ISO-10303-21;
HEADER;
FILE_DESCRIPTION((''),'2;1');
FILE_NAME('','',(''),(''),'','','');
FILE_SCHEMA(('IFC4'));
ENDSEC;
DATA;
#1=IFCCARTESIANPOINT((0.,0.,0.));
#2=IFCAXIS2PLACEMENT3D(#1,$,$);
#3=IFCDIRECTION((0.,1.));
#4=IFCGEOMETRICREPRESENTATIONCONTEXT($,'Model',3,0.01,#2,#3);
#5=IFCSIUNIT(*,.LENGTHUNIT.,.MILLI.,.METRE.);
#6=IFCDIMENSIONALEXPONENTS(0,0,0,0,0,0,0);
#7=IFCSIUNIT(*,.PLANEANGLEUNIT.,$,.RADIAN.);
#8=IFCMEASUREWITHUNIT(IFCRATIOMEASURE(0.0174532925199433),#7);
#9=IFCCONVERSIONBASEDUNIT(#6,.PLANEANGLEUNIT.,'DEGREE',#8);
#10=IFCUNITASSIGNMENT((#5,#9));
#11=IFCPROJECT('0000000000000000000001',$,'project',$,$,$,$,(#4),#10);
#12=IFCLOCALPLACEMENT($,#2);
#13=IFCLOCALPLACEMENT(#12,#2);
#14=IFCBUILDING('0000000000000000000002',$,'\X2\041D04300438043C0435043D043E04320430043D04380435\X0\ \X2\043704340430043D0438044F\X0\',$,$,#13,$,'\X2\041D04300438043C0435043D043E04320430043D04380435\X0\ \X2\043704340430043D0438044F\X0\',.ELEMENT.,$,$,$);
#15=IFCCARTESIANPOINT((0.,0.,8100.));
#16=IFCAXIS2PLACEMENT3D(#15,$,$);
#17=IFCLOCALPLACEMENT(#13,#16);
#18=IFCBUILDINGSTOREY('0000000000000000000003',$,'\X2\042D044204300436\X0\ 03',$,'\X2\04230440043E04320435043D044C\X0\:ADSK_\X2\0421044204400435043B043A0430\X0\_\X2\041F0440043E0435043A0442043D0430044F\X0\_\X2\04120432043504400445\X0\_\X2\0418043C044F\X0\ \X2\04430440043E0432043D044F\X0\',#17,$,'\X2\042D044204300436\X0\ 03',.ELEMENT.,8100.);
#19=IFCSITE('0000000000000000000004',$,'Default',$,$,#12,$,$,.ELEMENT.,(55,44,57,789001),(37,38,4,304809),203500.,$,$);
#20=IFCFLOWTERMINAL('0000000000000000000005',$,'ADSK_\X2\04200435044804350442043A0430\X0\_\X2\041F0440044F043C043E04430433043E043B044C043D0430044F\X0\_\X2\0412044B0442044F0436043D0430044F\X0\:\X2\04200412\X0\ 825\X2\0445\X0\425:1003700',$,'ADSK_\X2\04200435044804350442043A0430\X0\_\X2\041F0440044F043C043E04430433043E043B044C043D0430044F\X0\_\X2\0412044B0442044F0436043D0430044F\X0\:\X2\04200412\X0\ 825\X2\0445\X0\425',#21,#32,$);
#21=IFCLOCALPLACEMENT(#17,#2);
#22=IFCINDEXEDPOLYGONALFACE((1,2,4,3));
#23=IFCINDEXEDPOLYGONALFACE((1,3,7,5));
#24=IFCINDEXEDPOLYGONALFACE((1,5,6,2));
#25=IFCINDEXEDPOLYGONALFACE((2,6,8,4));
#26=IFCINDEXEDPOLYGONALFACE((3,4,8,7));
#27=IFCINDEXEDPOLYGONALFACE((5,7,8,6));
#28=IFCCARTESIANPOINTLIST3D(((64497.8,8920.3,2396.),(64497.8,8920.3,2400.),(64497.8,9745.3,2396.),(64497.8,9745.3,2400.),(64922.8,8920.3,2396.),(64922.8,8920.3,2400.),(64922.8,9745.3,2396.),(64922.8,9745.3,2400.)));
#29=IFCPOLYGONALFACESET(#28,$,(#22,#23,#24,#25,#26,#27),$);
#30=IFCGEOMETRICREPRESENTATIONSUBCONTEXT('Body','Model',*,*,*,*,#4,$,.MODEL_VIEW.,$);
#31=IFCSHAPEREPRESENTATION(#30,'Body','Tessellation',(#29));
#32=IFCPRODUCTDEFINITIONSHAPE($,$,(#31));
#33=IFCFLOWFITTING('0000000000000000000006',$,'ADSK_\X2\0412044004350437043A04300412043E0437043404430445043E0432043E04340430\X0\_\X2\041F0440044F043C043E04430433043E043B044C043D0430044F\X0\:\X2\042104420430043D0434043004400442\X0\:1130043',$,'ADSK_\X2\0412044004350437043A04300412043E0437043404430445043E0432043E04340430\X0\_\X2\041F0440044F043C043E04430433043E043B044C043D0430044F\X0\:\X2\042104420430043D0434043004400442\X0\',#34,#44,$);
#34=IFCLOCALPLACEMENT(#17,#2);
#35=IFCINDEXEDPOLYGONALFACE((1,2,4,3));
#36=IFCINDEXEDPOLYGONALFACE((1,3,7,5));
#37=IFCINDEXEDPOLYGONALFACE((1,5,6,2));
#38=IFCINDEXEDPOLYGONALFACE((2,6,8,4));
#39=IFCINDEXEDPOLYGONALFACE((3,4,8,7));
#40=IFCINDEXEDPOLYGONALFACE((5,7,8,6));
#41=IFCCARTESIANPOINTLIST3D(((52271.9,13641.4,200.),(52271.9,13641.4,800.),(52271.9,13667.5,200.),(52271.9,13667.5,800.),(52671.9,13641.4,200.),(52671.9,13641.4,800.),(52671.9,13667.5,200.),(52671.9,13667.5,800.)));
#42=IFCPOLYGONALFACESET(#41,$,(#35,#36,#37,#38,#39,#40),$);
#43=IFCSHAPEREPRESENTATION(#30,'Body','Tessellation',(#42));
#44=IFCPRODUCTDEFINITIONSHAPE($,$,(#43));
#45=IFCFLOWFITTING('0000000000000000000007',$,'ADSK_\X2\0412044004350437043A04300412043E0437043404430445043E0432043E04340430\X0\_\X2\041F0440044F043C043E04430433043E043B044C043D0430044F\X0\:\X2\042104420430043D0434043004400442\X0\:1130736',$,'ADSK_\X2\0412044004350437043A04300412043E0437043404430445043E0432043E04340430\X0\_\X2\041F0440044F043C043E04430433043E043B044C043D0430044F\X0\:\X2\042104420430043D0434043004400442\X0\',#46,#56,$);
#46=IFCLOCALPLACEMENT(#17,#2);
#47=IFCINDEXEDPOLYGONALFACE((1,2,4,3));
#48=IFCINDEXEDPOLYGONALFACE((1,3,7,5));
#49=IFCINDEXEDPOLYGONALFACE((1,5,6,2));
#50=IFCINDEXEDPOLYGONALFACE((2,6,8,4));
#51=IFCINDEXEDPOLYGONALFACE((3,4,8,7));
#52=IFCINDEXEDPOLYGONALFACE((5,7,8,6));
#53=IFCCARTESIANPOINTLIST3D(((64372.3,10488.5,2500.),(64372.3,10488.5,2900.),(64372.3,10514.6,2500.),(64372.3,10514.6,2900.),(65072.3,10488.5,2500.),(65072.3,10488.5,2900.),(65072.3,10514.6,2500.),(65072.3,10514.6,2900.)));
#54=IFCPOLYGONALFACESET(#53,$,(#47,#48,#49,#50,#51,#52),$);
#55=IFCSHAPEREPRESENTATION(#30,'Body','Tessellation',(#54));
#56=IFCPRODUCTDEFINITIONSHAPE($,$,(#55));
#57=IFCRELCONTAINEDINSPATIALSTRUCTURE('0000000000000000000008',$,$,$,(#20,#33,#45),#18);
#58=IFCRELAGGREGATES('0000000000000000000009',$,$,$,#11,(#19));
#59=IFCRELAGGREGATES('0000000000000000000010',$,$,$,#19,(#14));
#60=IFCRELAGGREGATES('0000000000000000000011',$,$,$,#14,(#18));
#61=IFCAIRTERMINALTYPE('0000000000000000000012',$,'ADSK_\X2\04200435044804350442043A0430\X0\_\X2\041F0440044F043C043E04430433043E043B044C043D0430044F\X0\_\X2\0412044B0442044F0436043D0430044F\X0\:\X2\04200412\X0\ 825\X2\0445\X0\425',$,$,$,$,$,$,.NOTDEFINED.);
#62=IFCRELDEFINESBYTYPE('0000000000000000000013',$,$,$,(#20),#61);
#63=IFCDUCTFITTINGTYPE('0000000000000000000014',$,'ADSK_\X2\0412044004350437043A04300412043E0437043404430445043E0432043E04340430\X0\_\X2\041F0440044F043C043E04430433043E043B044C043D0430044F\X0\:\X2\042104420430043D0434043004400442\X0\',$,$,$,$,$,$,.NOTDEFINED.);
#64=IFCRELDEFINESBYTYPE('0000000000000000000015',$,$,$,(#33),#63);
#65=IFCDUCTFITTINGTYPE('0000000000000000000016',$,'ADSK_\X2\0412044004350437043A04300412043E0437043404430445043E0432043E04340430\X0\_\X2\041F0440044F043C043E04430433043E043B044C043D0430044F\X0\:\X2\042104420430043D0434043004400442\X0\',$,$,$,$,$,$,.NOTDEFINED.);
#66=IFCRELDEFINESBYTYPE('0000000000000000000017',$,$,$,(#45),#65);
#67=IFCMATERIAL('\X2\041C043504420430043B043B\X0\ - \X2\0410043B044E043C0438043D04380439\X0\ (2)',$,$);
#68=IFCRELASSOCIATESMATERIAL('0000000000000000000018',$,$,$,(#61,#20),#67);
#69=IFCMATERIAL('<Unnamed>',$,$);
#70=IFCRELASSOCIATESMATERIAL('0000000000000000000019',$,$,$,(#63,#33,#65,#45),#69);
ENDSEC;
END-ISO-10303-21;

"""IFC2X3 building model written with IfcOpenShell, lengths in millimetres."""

from ifc_helpers import new_model, entity, si_unit, converted_unit, direction, frame, origin, origin_2d_with_axis, place, context, subcontext, project, spatial, rectangle, extrude, source, transform, mapped, material, type_object, type_shapes, element, save


model = new_model("IFC2X3")

# Units and contexts
model_context = context("Model", 3, precision=0.01, world=origin(), true_north=direction((0.0, 1.0)))
body_context = subcontext(model_context, "Body", "Model", "MODEL_VIEW")
ifc_project = project(units=[si_unit("LENGTHUNIT", "METRE", prefix="MILLI"), converted_unit("PLANEANGLEUNIT", "DEGREE", entity("IfcRatioMeasure", 0.0174532925199433), si_unit("PLANEANGLEUNIT", "RADIAN"), dimensions=[0, 0, 0, 0, 0, 0, 0])], contexts=[model_context])

# Site, building, storey
site_placement = place(None, origin())
site = spatial("IfcSite", under=ifc_project, at=site_placement, Name="Default", CompositionType="ELEMENT", RefLatitude=(55, 44, 57, 789001), RefLongitude=(37, 38, 4, 304809), RefElevation=203500.0)
building_placement = place(site_placement, origin())
building = spatial("IfcBuilding", under=site, at=building_placement, Name="Наименование здания", LongName="Наименование здания", CompositionType="ELEMENT")
storey_placement = place(building_placement, frame((0.0, 0.0, 8100.0)))
storey = spatial("IfcBuildingStorey", under=building, at=storey_placement, Name="Этаж 03", ObjectType="Уровень:ADSK_Стрелка_Проектная_Вверх_Имя уровня", LongName="Этаж 03", CompositionType="ELEMENT", Elevation=8100.0)

# Shared definitions
ifc_material_1 = material(Name="<Unnamed>")

# Flow terminal
ifc_material_2 = material(Name="Металл - Алюминий (2)")
air_terminal_type = type_object("IfcAirTerminalType", Name="ADSK_Решетка_Прямоугольная_Вытяжная:РВ 825х425", PredefinedType="NOTDEFINED", material=ifc_material_2)
shared_shape_1 = source(origin(), body_context, "Body", "SweptSolid", [
    extrude(rectangle(XDim=4.0, YDim=825.0, at=origin_2d_with_axis()), frame((0.0, -2.0, -212.5), z_axis=(0.0, 0.0, 1.0), x_axis=(0.0, 1.0, 0.0)), (0.0, 0.0, 1.0), 425.0),
])
type_shapes(air_terminal_type, [shared_shape_1])
flow_terminal_placement = place(storey_placement, frame((64710.3, 9332.8, 2400.0), z_axis=(1.0, 0.0, 0.0), x_axis=(0.0, 1.0, 0.0)))
element("IfcFlowTerminal", 1, at=flow_terminal_placement, inside=storey, type_object=air_terminal_type, material=ifc_material_2, Name="ADSK_Решетка_Прямоугольная_Вытяжная:РВ 825х425:1003700", ObjectType="ADSK_Решетка_Прямоугольная_Вытяжная:РВ 825х425", context=body_context, shape_type="MappedRepresentation", body=[
    mapped(shared_shape_1, transform((0.0, 0.0, 0.0), scale=1.0)),
])

# Flow fittings
duct_fitting_type_1 = type_object("IfcDuctFittingType", Name="ADSK_ВрезкаВоздуховода_Прямоугольная:Стандарт", PredefinedType="NOTDEFINED", material=ifc_material_1)
shared_shape_2 = source(origin(), body_context, "Body", "SweptSolid", [
    extrude(rectangle(XDim=600.0, YDim=26.1, at=origin_2d_with_axis()), frame((7.0, 0.0, -200.0), z_axis=(0.0, 0.0, 1.0), x_axis=(0.0, -1.0, 0.0)), (0.0, 0.0, 1.0), 400.0),
])
type_shapes(duct_fitting_type_1, [shared_shape_2])
flow_fitting_1_placement = place(storey_placement, frame((52471.9, 13647.5, 500.0), z_axis=(1.0, 0.0, 0.0), x_axis=(0.0, 1.0, 0.0)))
element("IfcFlowFitting", 2, at=flow_fitting_1_placement, inside=storey, type_object=duct_fitting_type_1, material=ifc_material_1, Name="ADSK_ВрезкаВоздуховода_Прямоугольная:Стандарт:1130043", ObjectType="ADSK_ВрезкаВоздуховода_Прямоугольная:Стандарт", context=body_context, shape_type="MappedRepresentation", body=[
    mapped(shared_shape_2, transform((0.0, 0.0, 0.0), scale=1.0)),
])
duct_fitting_type_2 = type_object("IfcDuctFittingType", Name="ADSK_ВрезкаВоздуховода_Прямоугольная:Стандарт", PredefinedType="NOTDEFINED", material=ifc_material_1)
shared_shape_3 = source(origin(), body_context, "Body", "SweptSolid", [
    extrude(rectangle(XDim=26.1, YDim=700.0, at=origin_2d_with_axis()), frame((7.0, 0.0, -200.0)), (0.0, 0.0, 1.0), 400.0),
])
type_shapes(duct_fitting_type_2, [shared_shape_3])
flow_fitting_2_placement = place(storey_placement, frame((64722.3, 10508.5, 2700.0), z_axis=(0.0, 0.0, -1.0), x_axis=(0.0, -1.0, 0.0)))
element("IfcFlowFitting", 3, at=flow_fitting_2_placement, inside=storey, type_object=duct_fitting_type_2, material=ifc_material_1, Name="ADSK_ВрезкаВоздуховода_Прямоугольная:Стандарт:1130736", ObjectType="ADSK_ВрезкаВоздуховода_Прямоугольная:Стандарт", context=body_context, shape_type="MappedRepresentation", body=[
    mapped(shared_shape_3, transform((0.0, 0.0, 0.0), scale=1.0)),
])

save(model, "model.ifc")
